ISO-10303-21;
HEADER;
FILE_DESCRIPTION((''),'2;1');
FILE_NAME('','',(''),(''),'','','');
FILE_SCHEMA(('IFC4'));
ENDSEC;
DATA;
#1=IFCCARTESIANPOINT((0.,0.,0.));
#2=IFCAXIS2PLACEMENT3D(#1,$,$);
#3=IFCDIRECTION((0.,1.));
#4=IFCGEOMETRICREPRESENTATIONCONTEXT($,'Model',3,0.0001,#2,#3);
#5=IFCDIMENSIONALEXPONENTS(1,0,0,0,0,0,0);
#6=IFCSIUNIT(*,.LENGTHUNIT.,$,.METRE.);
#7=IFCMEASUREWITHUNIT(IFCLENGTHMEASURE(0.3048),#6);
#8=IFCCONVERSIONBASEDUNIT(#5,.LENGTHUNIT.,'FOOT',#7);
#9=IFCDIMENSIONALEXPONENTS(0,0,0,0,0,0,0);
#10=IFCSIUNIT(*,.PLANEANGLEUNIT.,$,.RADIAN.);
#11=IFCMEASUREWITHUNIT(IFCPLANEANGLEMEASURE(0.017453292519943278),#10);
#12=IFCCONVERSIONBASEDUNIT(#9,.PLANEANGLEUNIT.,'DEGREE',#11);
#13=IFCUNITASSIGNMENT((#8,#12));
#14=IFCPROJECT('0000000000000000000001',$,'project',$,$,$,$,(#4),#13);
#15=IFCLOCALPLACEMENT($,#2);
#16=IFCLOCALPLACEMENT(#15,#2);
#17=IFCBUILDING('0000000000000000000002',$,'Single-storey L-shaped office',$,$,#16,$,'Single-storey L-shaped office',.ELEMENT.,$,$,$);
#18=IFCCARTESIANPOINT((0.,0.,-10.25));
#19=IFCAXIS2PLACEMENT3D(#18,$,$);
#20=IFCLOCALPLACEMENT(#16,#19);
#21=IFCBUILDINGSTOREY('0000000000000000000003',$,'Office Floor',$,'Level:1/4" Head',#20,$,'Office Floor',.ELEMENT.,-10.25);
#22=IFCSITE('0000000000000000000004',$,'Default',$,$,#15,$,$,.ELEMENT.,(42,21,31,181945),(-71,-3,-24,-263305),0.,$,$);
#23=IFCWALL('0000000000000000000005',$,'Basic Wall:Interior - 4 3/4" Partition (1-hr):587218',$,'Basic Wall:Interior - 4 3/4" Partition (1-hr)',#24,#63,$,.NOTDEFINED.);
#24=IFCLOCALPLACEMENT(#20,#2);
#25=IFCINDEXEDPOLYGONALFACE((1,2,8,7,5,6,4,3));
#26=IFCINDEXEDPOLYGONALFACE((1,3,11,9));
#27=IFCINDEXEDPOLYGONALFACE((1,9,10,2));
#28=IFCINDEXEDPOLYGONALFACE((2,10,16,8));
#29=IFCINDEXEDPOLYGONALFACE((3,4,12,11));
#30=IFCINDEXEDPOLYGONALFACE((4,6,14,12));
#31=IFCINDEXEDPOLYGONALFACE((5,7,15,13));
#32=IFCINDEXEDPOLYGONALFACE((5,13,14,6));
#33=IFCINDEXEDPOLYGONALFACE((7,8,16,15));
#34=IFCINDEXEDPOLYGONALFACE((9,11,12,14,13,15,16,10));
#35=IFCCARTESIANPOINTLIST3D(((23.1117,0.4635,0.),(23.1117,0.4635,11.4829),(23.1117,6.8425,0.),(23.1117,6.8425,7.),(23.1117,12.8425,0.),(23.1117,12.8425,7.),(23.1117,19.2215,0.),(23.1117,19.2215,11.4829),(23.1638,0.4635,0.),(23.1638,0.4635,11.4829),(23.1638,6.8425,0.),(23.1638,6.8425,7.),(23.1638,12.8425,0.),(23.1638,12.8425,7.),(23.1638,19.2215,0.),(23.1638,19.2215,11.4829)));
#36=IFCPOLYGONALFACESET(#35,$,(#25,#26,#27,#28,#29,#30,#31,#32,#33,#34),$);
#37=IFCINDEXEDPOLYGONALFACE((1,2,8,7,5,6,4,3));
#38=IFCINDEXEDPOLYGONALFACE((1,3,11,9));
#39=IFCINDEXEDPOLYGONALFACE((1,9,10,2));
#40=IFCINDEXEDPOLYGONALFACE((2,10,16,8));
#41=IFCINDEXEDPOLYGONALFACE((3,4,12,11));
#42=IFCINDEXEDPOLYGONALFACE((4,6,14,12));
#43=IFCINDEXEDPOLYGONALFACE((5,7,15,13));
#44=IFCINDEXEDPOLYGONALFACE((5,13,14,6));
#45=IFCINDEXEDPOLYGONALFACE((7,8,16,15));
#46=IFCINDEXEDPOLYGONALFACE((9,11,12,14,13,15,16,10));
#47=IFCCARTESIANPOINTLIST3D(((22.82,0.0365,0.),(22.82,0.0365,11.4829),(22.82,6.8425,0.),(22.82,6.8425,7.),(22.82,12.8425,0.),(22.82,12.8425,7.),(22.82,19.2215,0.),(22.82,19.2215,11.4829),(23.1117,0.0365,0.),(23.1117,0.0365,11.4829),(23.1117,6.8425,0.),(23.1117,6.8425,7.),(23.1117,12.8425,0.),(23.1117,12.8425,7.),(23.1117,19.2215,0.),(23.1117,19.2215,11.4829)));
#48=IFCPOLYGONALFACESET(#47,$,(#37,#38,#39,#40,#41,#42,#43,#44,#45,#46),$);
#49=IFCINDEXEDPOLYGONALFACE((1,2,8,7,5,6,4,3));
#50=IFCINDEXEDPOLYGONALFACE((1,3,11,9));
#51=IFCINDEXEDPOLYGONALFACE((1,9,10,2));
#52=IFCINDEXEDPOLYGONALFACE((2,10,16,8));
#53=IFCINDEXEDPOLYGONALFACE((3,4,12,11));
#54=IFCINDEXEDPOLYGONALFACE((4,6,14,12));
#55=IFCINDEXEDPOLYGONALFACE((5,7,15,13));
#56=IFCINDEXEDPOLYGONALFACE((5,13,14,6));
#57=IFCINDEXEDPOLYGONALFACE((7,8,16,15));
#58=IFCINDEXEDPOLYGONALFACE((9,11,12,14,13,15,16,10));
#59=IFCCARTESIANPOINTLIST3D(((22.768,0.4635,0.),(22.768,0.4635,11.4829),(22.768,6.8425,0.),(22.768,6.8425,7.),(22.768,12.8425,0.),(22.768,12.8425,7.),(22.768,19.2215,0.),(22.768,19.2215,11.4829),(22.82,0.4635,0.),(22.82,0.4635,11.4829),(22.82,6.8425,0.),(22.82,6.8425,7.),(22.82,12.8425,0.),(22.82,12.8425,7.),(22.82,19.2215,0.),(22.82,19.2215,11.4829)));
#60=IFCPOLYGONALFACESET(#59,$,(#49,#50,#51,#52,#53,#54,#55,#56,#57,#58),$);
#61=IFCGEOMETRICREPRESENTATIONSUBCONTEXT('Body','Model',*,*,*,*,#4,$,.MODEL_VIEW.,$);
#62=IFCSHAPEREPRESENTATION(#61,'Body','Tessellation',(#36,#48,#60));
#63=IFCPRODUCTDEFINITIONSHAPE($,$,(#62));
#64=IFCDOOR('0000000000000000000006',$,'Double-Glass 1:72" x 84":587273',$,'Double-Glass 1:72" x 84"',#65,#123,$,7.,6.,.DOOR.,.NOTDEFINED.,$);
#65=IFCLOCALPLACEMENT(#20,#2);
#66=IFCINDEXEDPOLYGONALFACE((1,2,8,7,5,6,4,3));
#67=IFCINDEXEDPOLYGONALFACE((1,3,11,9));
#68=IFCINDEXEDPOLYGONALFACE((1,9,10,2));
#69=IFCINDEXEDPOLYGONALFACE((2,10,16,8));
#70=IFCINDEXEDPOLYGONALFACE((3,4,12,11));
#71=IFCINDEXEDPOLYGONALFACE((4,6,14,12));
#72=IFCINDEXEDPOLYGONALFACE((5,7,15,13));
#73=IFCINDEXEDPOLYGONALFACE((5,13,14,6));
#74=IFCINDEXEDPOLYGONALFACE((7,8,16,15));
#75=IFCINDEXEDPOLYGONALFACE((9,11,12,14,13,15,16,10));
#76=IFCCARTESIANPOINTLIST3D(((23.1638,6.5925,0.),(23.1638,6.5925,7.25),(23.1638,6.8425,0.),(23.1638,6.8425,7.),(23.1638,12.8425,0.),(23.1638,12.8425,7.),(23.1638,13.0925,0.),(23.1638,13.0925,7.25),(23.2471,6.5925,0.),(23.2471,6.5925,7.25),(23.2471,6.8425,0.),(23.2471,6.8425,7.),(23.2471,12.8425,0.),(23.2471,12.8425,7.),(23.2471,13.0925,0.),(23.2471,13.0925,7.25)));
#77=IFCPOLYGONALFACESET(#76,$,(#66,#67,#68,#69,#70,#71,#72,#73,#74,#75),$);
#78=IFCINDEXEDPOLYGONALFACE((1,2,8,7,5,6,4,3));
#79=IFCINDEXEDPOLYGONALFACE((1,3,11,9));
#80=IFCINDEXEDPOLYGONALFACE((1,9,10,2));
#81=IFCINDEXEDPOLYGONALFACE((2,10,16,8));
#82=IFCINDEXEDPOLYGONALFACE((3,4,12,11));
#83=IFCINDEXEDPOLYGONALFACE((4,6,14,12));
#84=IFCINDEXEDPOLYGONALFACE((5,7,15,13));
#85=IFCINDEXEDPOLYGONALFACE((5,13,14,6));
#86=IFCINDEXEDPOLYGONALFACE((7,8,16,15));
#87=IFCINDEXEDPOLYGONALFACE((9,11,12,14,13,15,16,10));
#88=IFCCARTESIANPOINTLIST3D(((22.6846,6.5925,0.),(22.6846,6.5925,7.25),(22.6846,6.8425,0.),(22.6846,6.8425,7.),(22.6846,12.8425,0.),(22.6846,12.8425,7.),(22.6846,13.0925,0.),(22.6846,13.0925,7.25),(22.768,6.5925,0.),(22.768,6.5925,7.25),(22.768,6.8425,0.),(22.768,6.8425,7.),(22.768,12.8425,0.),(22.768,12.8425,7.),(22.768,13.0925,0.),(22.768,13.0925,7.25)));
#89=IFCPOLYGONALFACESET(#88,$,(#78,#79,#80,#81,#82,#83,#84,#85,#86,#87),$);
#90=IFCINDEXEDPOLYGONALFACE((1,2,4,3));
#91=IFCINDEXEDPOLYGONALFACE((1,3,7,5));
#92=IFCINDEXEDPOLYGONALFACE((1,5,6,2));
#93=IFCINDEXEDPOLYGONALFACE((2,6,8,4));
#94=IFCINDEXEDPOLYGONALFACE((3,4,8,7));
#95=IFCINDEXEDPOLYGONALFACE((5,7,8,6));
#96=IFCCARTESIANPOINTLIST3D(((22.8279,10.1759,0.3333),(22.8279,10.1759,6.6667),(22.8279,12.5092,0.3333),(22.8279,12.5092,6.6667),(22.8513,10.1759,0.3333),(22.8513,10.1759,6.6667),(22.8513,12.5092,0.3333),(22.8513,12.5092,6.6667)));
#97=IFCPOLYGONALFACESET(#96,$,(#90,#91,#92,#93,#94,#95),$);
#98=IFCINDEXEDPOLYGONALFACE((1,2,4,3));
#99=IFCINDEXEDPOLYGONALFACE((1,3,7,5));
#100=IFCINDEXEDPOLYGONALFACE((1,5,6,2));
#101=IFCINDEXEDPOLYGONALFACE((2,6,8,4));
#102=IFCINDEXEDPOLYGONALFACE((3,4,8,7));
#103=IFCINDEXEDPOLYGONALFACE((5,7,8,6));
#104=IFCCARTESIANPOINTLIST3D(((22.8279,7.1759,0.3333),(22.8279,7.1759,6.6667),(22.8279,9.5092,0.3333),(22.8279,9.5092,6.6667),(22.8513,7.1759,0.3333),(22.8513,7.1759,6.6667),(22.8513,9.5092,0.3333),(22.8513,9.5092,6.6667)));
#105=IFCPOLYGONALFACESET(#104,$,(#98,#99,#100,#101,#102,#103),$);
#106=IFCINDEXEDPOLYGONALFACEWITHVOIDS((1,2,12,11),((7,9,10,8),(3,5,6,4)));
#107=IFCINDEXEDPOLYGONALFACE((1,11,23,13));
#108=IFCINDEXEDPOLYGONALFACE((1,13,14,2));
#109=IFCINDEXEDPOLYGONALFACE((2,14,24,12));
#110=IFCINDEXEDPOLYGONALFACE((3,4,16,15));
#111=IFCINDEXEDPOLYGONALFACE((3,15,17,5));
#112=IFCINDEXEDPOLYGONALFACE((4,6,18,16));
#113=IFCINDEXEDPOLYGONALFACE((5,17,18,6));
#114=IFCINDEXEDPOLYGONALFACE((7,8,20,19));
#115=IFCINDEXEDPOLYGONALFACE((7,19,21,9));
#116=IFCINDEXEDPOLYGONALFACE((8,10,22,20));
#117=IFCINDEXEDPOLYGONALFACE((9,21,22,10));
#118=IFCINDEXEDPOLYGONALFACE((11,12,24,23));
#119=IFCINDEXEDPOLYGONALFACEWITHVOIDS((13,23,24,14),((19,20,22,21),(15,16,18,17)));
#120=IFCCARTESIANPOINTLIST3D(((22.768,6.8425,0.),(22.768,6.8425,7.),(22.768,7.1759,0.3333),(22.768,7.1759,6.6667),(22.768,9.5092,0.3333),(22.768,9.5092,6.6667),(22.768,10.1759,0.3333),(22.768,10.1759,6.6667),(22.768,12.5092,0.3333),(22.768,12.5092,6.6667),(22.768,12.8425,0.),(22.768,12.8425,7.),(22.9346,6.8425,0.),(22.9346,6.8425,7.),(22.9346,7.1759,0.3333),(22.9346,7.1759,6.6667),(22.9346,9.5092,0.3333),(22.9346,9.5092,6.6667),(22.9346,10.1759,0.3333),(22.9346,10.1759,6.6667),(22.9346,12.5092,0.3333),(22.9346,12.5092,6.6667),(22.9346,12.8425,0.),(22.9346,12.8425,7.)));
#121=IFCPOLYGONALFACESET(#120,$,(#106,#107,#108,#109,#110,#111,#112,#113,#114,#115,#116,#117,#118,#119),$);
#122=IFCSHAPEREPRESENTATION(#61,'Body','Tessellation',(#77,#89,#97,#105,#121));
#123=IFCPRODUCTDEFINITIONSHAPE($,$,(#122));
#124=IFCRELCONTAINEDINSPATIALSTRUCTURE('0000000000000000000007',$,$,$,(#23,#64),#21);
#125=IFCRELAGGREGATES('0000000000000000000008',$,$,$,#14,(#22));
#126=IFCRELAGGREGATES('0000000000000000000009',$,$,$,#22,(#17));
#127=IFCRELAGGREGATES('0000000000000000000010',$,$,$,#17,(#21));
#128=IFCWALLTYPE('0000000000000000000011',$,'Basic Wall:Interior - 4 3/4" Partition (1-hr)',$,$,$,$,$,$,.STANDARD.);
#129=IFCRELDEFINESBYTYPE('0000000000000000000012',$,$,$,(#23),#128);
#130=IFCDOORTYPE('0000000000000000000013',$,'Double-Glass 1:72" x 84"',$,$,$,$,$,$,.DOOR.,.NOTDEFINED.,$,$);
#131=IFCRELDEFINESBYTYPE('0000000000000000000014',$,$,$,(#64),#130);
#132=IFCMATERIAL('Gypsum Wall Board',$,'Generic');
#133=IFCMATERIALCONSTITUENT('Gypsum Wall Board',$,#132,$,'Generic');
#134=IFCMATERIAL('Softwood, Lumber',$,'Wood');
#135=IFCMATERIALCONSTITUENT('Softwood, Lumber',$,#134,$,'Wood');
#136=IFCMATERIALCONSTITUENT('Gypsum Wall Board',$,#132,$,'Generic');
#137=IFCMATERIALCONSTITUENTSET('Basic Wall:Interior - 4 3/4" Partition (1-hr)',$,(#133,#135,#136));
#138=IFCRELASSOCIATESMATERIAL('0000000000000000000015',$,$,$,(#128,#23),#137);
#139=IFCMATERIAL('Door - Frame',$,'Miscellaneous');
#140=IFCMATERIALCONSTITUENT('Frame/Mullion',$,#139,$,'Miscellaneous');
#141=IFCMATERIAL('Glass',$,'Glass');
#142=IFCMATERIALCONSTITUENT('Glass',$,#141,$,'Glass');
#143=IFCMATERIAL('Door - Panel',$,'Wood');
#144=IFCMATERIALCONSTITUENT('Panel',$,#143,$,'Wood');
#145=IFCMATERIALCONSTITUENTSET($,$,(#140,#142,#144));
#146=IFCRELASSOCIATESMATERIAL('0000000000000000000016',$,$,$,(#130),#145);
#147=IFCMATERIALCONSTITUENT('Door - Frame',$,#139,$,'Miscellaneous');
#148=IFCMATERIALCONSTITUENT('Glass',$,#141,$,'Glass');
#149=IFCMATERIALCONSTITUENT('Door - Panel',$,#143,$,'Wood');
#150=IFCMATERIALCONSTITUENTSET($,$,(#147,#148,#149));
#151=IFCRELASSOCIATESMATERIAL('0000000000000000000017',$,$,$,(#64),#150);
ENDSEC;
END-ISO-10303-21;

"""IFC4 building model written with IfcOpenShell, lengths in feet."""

from ifc_helpers import new_model, entity, si_unit, converted_unit, direction, frame, origin, place, context, subcontext, project, spatial, indexed_curve, outline, extrude, source, transform, mapped, material, constituent, constituent_set, type_object, type_shapes, element, fill, save


model = new_model("IFC4")

# Units and contexts
model_context = context("Model", 3, precision=0.0001, world=origin(), true_north=direction((0.0, 1.0)))
body_context = subcontext(model_context, "Body", "Model", "MODEL_VIEW")
ifc_project = project(units=[converted_unit("LENGTHUNIT", "FOOT", entity("IfcLengthMeasure", 0.3048), si_unit("LENGTHUNIT", "METRE"), dimensions=[1, 0, 0, 0, 0, 0, 0]), converted_unit("PLANEANGLEUNIT", "DEGREE", entity("IfcPlaneAngleMeasure", 0.017453292519943278), si_unit("PLANEANGLEUNIT", "RADIAN"), dimensions=[0, 0, 0, 0, 0, 0, 0])], contexts=[model_context])

# Site, building, storey
site_placement = place(None, origin())
site = spatial("IfcSite", under=ifc_project, at=site_placement, Name="Default", CompositionType="ELEMENT", RefLatitude=(42, 21, 31, 181945), RefLongitude=(-71, -3, -24, -263305), RefElevation=0.0)
building_placement = place(site_placement, origin())
building = spatial("IfcBuilding", under=site, at=building_placement, Name="Single-storey L-shaped office", LongName="Single-storey L-shaped office", CompositionType="ELEMENT")
storey_placement = place(building_placement, frame((0.0, 0.0, -10.25)))
storey = spatial("IfcBuildingStorey", under=building, at=storey_placement, Name="Office Floor", ObjectType="Level:1/4\" Head", LongName="Office Floor", CompositionType="ELEMENT", Elevation=-10.25)

# Shared definitions
ifc_material_1 = material(Name="Softwood, Lumber", Category="Wood")
ifc_material_2 = material(Name="Gypsum Wall Board", Category="Generic")
ifc_material_3 = material(Name="Door - Frame", Category="Miscellaneous")
ifc_material_4 = material(Name="Glass", Category="Glass")
ifc_material_5 = material(Name="Door - Panel", Category="Wood")

# Wall, opening, door
ifc_constituent_1 = constituent(ifc_material_2, Name="Gypsum Wall Board", Category="Generic")
ifc_constituent_2 = constituent(ifc_material_1, Name="Softwood, Lumber", Category="Wood")
ifc_constituent_3 = constituent(ifc_material_2, Name="Gypsum Wall Board", Category="Generic")
ifc_constituent_set_1 = constituent_set(constituents=[ifc_constituent_1, ifc_constituent_2, ifc_constituent_3], Name="Basic Wall:Interior - 4 3/4\" Partition (1-hr)")
wall_type_1 = type_object("IfcWallType", Name="Basic Wall:Interior - 4 3/4\" Partition (1-hr)", PredefinedType="STANDARD", material=ifc_constituent_set_1)
wall_1_placement = place(storey_placement, frame((22.9659, 0.4635, 0.0), z_axis=(0.0, 0.0, 1.0), x_axis=(0.0, 1.0, 0.0)))
wall_1 = element("IfcWall", 1, at=wall_1_placement, inside=storey, type_object=wall_type_1, material=ifc_constituent_set_1, Name="Basic Wall:Interior - 4 3/4\" Partition (1-hr):587218", ObjectType="Basic Wall:Interior - 4 3/4\" Partition (1-hr)", PredefinedType="NOTDEFINED", context=body_context, shape_type="SweptSolid", body=[
    extrude(outline(indexed_curve([(-4.6207, -3.0), (-4.6207, -9.379), (6.8622, -9.379), (6.8622, 9.379), (-4.6207, 9.379), (-4.6207, 3.0), (2.3793, 3.0), (2.3793, -3.0), (-4.6207, -3.0)], self_intersect=False)), frame((9.379, -0.1458, 4.6207), z_axis=(0.0, 1.0, 0.0), x_axis=(0.0, 0.0, 1.0)), (0.0, 0.0, -1.0), 0.0521),
    extrude(outline(indexed_curve([(-4.6207, -2.8932), (-4.6207, -9.6993), (6.8622, -9.6993), (6.8622, 9.4857), (-4.6207, 9.4857), (-4.6207, 3.1068), (2.3793, 3.1068), (2.3793, -2.8932), (-4.6207, -2.8932)], self_intersect=False)), frame((9.2722, 0.1458, 4.6207), z_axis=(0.0, 1.0, 0.0), x_axis=(0.0, 0.0, 1.0)), (0.0, 0.0, -1.0), 0.2917),
    extrude(outline(indexed_curve([(-4.6207, -9.379), (6.8622, -9.379), (6.8622, 9.379), (-4.6207, 9.379), (-4.6207, 3.0), (2.3793, 3.0), (2.3793, -3.0), (-4.6207, -3.0), (-4.6207, -9.379)], self_intersect=False)), frame((9.379, 0.1979, 4.6207), z_axis=(0.0, -1.0, 0.0), x_axis=(0.0, 0.0, 1.0)), (0.0, 0.0, 1.0), 0.0521),
])
opening_1_placement = place(wall_1_placement, frame((6.379, -0.1979, 0.0)))
opening_1 = element("IfcOpeningElement", 2, at=opening_1_placement, cuts=wall_1, PredefinedType="OPENING", context=body_context, shape_type="SweptSolid", body=[
    extrude(outline(indexed_curve([(0.0, 0.0), (7.0, 0.0), (7.0, 6.0), (0.0, 6.0), (0.0, 0.0)], self_intersect=False)), frame((0.0, 0.0, 0.0), z_axis=(0.0, 1.0, 0.0), x_axis=(0.0, 0.0, 1.0)), (0.0, 0.0, 1.0), 0.3958),
])
ifc_constituent_4 = constituent(ifc_material_3, Name="Door - Frame", Category="Miscellaneous")
ifc_constituent_5 = constituent(ifc_material_4, Name="Glass", Category="Glass")
ifc_constituent_6 = constituent(ifc_material_5, Name="Door - Panel", Category="Wood")
ifc_constituent_set_2 = constituent_set(constituents=[ifc_constituent_4, ifc_constituent_5, ifc_constituent_6])
ifc_constituent_7 = constituent(ifc_material_3, Name="Frame/Mullion", Category="Miscellaneous")
ifc_constituent_8 = constituent(ifc_material_4, Name="Glass", Category="Glass")
ifc_constituent_9 = constituent(ifc_material_5, Name="Panel", Category="Wood")
ifc_constituent_set_3 = constituent_set(constituents=[ifc_constituent_7, ifc_constituent_8, ifc_constituent_9])
door_type_1 = type_object("IfcDoorType", Name="Double-Glass 1:72\" x 84\"", OperationType="NOTDEFINED", PredefinedType="DOOR", material=ifc_constituent_set_3)
shared_shape_1 = source(origin(), body_context, "Body", "SweptSolid", [
    extrude(outline(indexed_curve([(-3.25, -3.5625), (-3.0, -3.5625), (-3.0, 3.4375), (3.0, 3.4375), (3.0, -3.5625), (3.25, -3.5625), (3.25, 3.6875), (-3.25, 3.6875), (-3.25, -3.5625)], self_intersect=False)), frame((3.0, -0.0833, 3.5625), z_axis=(0.0, 1.0, 0.0), x_axis=(-1.0, 0.0, 0.0)), (0.0, 0.0, 1.0), 0.0833),
    extrude(outline(indexed_curve([(-3.0, -3.4375), (-3.0, 3.5625), (-3.25, 3.5625), (-3.25, -3.6875), (3.25, -3.6875), (3.25, 3.5625), (3.0, 3.5625), (3.0, -3.4375), (-3.0, -3.4375)], self_intersect=False)), frame((3.0, 0.3958, 3.5625), z_axis=(0.0, -1.0, 0.0), x_axis=(-1.0, 0.0, 0.0)), (0.0, 0.0, -1.0), 0.0833),
    extrude(outline(indexed_curve([(-0.0117, -1.1667), (0.0117, -1.1667), (0.0117, 1.1667), (-0.0117, 1.1667), (-0.0117, -1.1667)], self_intersect=False)), frame((4.5, 0.3242, 0.3333), z_axis=(0.0, 0.0, 1.0), x_axis=(0.0, 1.0, 0.0)), (0.0, 0.0, 1.0), 6.3333),
    extrude(outline(indexed_curve([(-0.0117, -1.1667), (0.0117, -1.1667), (0.0117, 1.1667), (-0.0117, 1.1667), (-0.0117, -1.1667)], self_intersect=False)), frame((1.5, 0.3242, 0.3333), z_axis=(0.0, 0.0, 1.0), x_axis=(0.0, 1.0, 0.0)), (0.0, 0.0, 1.0), 6.3333),
    extrude(outline(indexed_curve([(-3.5, -3.0), (3.5, -3.0), (3.5, 3.0), (-3.5, 3.0), (-3.5, -3.0)], self_intersect=False), holes=[indexed_curve([(-3.1667, 0.3333), (-3.1667, 2.6667), (3.1667, 2.6667), (3.1667, 0.3333), (-3.1667, 0.3333)], self_intersect=False), indexed_curve([(-3.1667, -2.6667), (-3.1667, -0.3333), (3.1667, -0.3333), (3.1667, -2.6667), (-3.1667, -2.6667)], self_intersect=False)]), frame((3.0, 0.2292, 3.5), z_axis=(0.0, 1.0, 0.0), x_axis=(0.0, 0.0, -1.0)), (0.0, 0.0, 1.0), 0.1667),
])
type_shapes(door_type_1, [shared_shape_1])
door_1_placement = place(opening_1_placement, origin())
door_1 = element("IfcDoor", 3, at=door_1_placement, inside=storey, type_object=door_type_1, material=ifc_constituent_set_2, Name="Double-Glass 1:72\" x 84\":587273", ObjectType="Double-Glass 1:72\" x 84\"", OperationType="NOTDEFINED", OverallHeight=7.0, OverallWidth=6.0, PredefinedType="DOOR", context=body_context, shape_type="MappedRepresentation", body=[
    mapped(shared_shape_1, transform((0.0, 0.0, 0.0), scale=1.0)),
])
fill(opening_1, door_1)

save(model, "model.ifc")
